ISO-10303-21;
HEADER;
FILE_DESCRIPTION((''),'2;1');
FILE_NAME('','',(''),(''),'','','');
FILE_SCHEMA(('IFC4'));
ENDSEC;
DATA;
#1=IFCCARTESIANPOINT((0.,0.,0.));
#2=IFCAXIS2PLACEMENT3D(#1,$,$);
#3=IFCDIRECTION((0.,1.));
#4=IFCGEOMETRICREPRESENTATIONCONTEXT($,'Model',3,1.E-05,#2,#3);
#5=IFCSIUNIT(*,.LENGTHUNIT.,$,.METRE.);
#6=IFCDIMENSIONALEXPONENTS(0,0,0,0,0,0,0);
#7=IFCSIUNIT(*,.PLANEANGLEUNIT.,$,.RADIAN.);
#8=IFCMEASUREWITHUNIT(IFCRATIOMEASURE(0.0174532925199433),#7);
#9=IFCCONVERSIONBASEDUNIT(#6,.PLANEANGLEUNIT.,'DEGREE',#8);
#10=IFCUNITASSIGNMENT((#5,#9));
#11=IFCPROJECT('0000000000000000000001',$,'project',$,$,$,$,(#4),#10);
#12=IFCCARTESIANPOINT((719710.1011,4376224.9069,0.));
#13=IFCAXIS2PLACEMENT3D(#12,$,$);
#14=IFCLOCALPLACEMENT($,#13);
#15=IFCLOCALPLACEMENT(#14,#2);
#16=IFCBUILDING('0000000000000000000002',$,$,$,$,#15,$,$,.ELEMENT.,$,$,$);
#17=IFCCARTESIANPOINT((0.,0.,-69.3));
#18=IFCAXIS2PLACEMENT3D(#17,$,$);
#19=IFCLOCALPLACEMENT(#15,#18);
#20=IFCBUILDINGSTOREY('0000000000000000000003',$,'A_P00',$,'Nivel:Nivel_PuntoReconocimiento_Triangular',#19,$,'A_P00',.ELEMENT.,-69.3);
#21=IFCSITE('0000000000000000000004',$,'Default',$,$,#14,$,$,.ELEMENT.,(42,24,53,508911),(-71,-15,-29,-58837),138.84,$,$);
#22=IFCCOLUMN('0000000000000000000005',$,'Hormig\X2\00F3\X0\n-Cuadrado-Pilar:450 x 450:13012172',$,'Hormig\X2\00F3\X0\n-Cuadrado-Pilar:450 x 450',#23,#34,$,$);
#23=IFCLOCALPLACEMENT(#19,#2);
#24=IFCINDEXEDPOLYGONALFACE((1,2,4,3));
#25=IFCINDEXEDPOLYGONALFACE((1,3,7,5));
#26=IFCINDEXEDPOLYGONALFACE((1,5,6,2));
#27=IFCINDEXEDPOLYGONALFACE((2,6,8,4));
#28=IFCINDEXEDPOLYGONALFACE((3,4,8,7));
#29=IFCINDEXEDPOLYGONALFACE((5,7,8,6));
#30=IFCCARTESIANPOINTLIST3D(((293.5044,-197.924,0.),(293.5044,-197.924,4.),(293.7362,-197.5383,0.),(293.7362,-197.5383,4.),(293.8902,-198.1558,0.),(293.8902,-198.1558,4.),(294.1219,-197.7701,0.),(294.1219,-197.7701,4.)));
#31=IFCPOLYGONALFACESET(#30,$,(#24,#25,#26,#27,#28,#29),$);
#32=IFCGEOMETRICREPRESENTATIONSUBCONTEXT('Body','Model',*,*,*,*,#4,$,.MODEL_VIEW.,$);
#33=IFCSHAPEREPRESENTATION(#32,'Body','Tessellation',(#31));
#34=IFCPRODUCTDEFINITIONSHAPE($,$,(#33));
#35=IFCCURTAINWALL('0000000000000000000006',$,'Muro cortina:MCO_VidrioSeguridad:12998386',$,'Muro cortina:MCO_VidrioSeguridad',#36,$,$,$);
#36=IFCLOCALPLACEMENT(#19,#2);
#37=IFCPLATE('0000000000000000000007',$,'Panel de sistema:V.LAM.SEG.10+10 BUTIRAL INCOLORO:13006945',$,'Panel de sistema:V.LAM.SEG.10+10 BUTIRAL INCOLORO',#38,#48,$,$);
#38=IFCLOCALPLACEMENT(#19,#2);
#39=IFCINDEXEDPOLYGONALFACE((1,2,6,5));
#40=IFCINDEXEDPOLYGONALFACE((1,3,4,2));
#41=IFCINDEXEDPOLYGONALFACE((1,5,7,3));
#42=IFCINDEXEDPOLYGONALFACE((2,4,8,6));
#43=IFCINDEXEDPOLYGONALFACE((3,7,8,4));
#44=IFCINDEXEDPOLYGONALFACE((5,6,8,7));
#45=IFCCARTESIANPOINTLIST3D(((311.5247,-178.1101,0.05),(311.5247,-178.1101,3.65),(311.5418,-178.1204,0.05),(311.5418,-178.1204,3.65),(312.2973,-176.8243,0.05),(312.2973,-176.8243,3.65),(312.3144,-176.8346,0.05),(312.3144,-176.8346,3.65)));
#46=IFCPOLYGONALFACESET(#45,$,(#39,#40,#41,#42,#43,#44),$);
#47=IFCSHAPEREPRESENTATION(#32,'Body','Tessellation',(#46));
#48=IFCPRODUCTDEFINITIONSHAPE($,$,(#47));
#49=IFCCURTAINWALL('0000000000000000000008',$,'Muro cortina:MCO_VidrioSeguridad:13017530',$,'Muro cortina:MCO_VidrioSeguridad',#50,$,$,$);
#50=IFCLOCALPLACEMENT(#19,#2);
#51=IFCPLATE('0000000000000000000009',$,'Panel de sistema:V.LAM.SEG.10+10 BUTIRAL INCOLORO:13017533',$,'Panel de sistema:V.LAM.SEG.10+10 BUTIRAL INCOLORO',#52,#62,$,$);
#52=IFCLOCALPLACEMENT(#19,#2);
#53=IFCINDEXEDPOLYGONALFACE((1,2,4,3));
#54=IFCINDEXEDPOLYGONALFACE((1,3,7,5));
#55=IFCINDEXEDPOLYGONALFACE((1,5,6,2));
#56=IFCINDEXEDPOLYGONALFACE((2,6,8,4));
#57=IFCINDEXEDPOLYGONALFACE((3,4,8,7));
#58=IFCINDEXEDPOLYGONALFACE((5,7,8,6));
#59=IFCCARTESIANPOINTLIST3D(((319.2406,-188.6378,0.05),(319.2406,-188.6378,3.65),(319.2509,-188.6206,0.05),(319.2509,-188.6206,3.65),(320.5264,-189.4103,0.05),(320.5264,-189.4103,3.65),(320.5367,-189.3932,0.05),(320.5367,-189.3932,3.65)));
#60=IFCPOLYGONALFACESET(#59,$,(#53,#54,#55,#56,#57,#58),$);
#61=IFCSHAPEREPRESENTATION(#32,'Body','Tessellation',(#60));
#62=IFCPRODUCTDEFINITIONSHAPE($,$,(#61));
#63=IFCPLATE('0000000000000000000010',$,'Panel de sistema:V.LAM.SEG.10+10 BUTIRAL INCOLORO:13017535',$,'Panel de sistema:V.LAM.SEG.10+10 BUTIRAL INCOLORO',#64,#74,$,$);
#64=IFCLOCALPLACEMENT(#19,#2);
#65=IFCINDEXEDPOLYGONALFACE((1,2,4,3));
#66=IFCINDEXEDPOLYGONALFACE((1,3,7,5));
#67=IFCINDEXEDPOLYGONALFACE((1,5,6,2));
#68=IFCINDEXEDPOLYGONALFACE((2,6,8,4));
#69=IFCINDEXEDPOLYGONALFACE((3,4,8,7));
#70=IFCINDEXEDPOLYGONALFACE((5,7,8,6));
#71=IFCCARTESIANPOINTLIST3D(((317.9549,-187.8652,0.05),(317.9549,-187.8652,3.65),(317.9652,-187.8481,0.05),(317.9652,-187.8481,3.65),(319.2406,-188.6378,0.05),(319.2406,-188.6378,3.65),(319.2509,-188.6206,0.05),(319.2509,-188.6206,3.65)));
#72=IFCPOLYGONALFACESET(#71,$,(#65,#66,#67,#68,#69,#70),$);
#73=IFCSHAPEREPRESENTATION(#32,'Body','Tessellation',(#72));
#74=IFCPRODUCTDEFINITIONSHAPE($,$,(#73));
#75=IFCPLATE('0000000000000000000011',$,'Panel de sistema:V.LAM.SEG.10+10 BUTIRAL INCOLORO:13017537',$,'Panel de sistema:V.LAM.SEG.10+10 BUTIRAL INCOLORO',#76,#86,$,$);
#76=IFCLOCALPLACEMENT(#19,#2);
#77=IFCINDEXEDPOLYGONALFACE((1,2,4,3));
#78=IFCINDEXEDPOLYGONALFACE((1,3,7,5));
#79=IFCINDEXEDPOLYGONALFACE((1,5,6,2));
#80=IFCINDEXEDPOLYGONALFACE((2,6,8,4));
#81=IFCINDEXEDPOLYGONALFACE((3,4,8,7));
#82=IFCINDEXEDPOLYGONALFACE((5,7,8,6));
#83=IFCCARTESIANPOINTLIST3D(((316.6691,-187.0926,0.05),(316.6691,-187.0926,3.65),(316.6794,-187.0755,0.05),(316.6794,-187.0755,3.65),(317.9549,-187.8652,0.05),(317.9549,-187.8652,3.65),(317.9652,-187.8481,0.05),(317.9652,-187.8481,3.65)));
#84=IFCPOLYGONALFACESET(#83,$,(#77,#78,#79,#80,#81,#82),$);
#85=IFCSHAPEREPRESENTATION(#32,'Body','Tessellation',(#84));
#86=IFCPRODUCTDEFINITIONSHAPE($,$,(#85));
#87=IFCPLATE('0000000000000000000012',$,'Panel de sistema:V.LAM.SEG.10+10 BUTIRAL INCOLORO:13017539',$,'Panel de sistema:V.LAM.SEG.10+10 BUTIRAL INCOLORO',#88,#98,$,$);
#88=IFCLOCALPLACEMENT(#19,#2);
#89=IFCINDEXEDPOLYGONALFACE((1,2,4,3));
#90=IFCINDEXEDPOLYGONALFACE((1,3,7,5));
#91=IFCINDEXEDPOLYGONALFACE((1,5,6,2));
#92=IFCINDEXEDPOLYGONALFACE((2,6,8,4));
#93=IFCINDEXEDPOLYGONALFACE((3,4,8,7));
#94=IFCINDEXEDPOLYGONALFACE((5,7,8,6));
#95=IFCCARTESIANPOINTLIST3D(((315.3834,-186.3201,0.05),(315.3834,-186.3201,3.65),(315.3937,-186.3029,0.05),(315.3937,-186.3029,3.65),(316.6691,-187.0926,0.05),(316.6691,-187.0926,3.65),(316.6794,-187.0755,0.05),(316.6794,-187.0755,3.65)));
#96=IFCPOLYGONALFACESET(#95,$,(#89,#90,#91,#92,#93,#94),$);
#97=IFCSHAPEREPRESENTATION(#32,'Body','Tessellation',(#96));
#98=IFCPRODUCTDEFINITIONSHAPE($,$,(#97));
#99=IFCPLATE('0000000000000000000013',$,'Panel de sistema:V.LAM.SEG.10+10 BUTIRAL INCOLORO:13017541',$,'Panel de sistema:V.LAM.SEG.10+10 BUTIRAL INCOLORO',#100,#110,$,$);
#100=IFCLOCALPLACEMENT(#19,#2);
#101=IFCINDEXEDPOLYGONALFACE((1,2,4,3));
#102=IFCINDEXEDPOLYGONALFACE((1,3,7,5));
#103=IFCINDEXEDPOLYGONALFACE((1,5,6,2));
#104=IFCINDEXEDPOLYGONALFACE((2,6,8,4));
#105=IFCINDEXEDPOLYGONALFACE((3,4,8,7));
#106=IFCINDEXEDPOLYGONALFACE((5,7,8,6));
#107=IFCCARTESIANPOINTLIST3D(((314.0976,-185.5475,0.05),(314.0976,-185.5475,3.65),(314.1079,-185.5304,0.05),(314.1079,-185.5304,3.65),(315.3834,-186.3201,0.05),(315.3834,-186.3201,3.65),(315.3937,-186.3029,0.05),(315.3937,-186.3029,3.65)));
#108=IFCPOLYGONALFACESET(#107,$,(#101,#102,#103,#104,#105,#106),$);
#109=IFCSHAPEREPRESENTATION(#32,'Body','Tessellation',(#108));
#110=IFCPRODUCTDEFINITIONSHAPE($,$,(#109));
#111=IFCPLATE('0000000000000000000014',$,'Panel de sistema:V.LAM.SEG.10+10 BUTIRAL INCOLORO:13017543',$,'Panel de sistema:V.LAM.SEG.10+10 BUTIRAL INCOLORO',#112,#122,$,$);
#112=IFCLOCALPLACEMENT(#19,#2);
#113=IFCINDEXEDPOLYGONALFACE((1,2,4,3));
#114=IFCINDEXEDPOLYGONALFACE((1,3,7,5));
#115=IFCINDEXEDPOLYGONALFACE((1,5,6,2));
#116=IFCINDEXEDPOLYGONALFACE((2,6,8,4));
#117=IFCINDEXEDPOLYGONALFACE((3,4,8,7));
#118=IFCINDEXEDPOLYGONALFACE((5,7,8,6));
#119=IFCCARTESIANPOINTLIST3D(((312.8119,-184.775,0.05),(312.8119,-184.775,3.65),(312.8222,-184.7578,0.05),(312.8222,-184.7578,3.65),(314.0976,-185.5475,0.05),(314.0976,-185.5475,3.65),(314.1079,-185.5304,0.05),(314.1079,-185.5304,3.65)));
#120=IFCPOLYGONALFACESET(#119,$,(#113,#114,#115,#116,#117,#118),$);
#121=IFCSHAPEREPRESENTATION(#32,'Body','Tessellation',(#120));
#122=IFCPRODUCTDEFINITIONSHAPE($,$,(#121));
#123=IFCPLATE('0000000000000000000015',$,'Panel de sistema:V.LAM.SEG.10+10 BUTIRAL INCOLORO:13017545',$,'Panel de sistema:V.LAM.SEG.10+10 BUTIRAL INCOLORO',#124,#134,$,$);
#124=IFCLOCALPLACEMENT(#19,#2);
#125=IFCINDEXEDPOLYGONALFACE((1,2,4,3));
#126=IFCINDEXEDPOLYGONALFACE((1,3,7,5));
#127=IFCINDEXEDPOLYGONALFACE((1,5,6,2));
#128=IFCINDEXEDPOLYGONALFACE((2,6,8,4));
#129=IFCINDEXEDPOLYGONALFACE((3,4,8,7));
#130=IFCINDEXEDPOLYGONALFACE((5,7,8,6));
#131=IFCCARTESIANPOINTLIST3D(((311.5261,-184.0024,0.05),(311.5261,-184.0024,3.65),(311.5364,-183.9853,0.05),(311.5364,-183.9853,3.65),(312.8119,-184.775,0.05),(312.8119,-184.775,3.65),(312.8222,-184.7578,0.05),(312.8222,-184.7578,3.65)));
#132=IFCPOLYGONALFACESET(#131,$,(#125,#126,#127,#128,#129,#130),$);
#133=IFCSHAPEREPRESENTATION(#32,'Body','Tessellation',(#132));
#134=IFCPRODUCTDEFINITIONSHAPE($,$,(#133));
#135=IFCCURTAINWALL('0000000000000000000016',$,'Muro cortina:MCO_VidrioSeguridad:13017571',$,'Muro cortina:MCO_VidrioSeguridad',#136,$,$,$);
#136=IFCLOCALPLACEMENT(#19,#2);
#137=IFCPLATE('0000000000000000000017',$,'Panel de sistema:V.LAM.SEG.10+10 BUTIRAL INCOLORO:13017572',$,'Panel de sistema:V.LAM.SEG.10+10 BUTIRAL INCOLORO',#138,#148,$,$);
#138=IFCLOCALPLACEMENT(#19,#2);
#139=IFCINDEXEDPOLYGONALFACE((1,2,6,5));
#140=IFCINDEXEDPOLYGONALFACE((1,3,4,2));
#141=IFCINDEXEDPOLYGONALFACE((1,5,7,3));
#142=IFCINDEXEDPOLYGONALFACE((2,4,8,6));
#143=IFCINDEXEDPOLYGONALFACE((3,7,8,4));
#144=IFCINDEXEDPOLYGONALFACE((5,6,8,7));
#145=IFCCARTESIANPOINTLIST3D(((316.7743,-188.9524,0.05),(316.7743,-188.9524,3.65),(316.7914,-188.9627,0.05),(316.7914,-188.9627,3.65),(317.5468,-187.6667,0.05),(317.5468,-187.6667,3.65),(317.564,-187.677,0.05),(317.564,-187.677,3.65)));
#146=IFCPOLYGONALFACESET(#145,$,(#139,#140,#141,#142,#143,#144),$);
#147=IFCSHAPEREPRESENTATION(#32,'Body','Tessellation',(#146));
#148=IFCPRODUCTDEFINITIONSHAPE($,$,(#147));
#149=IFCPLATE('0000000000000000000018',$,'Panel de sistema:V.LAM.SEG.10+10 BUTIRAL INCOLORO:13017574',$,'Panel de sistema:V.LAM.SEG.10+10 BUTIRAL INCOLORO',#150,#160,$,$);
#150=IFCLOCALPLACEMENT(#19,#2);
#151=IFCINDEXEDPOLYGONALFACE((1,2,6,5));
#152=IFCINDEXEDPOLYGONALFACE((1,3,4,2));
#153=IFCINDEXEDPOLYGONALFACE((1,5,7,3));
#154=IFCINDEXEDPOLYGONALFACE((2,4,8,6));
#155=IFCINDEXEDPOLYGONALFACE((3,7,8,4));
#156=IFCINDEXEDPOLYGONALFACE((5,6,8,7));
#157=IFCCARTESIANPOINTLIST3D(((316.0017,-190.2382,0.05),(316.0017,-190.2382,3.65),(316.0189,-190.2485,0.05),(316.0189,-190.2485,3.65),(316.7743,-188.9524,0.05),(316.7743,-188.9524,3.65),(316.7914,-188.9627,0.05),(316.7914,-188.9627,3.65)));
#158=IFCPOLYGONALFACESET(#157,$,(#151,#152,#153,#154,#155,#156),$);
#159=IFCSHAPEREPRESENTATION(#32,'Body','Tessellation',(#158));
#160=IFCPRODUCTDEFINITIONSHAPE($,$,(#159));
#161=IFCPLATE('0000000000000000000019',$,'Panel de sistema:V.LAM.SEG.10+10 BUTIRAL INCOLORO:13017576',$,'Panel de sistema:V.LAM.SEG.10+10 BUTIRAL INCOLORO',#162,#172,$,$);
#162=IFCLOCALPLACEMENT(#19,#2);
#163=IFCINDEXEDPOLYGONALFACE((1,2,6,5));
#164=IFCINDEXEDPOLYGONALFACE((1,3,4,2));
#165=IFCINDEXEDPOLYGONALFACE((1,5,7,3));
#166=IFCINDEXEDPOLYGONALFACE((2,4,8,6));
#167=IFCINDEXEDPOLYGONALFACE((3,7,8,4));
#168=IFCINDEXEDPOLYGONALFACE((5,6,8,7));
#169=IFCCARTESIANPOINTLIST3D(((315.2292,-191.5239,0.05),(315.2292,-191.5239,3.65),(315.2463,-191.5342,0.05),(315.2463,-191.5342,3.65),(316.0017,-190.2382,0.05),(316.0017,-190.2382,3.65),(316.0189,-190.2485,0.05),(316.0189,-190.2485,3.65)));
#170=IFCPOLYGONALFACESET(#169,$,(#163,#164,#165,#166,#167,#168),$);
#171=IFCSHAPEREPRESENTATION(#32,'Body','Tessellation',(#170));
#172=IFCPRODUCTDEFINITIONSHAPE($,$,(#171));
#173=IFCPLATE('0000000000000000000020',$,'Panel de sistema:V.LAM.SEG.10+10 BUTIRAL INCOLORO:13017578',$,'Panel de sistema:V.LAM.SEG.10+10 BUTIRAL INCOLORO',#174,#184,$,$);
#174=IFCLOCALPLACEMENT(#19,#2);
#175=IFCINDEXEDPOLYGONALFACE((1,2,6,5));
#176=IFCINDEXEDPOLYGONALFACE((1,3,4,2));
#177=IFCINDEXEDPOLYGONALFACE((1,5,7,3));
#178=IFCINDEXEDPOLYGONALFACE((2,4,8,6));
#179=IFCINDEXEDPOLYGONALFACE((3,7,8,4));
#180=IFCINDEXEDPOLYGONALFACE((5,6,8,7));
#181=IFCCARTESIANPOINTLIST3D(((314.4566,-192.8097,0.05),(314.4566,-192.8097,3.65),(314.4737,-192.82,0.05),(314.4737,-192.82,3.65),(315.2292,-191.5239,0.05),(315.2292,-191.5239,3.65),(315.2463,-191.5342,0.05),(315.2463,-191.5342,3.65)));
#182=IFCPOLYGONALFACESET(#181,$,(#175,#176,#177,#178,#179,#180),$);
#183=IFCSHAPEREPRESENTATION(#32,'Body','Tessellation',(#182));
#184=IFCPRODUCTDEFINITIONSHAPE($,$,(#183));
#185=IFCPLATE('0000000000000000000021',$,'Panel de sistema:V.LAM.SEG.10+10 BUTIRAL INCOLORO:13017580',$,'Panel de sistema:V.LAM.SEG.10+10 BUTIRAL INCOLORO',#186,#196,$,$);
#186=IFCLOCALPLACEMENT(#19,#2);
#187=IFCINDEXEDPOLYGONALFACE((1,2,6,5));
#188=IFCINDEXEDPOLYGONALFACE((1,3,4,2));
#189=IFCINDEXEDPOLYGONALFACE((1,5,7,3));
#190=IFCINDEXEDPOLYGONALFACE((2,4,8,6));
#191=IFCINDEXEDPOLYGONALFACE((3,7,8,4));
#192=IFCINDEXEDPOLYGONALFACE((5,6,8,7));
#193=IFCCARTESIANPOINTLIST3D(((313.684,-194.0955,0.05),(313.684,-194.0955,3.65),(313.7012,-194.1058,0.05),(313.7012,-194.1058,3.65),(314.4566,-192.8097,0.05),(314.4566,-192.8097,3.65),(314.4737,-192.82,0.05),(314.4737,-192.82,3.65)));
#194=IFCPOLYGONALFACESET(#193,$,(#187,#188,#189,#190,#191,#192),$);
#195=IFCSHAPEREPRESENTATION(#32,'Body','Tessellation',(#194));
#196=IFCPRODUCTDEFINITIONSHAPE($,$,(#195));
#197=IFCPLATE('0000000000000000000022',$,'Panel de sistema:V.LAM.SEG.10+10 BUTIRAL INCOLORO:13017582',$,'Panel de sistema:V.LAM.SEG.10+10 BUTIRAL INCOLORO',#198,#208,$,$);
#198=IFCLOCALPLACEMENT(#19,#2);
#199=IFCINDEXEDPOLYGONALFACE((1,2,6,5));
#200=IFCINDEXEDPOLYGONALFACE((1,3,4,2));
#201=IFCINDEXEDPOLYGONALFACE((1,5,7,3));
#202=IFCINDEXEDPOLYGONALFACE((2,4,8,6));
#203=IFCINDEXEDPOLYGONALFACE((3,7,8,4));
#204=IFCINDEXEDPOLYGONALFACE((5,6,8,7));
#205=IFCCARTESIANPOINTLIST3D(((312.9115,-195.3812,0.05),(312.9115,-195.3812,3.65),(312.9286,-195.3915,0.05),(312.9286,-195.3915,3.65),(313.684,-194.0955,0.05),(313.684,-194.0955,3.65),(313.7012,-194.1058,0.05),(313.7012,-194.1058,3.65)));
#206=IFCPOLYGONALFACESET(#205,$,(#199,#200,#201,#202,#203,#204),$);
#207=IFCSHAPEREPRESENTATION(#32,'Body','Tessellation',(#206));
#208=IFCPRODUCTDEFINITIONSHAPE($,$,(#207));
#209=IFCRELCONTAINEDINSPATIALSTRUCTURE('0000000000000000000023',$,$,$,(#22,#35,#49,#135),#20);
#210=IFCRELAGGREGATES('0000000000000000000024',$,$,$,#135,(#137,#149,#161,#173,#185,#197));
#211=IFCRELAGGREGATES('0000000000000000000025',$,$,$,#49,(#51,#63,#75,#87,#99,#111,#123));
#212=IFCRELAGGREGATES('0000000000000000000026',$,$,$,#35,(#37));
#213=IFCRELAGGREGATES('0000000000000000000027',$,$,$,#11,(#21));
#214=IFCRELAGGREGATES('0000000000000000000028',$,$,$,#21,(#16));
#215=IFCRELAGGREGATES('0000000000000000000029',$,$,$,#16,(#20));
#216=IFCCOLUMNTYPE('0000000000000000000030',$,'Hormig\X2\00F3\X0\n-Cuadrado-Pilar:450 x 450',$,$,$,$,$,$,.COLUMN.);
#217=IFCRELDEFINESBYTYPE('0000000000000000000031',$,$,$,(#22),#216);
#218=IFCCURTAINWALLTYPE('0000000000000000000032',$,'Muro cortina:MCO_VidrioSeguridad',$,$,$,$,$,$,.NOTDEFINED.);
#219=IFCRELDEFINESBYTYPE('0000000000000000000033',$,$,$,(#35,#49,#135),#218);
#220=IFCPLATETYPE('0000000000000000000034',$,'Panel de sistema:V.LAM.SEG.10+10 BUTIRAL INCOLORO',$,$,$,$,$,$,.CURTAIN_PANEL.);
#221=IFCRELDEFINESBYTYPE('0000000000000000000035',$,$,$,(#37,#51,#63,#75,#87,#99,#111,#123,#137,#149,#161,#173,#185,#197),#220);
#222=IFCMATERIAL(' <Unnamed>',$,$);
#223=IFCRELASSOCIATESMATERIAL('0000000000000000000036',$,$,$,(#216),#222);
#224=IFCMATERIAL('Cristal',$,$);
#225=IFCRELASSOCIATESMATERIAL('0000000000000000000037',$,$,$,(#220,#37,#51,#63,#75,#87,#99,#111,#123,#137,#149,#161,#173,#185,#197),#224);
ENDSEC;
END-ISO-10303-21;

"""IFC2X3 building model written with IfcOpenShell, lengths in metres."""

from ifc_helpers import new_model, entity, si_unit, converted_unit, direction, frame, origin, origin_2d_with_axis, place, context, subcontext, project, spatial, rectangle, extrude, source, transform, mapped, material, type_object, type_shapes, element, aggregate, save


model = new_model("IFC2X3")

# Units and contexts
model_context = context("Model", 3, precision=1e-05, world=origin(), true_north=direction((0.0, 1.0)))
body_context = subcontext(model_context, "Body", "Model", "MODEL_VIEW")
ifc_project = project(units=[si_unit("LENGTHUNIT", "METRE"), converted_unit("PLANEANGLEUNIT", "DEGREE", entity("IfcRatioMeasure", 0.0174532925199433), si_unit("PLANEANGLEUNIT", "RADIAN"), dimensions=[0, 0, 0, 0, 0, 0, 0])], contexts=[model_context])

# Site, building, storey
site_placement = place(None, frame((719710.1011, 4376224.9069, 0.0)))
site = spatial("IfcSite", under=ifc_project, at=site_placement, Name="Default", CompositionType="ELEMENT", RefLatitude=(42, 24, 53, 508911), RefLongitude=(-71, -15, -29, -58837), RefElevation=138.84)
building_placement = place(site_placement, origin())
building = spatial("IfcBuilding", under=site, at=building_placement, CompositionType="ELEMENT")
storey_placement = place(building_placement, frame((0.0, 0.0, -69.3)))
storey = spatial("IfcBuildingStorey", under=building, at=storey_placement, Name="A_P00", ObjectType="Nivel:Nivel_PuntoReconocimiento_Triangular", LongName="A_P00", CompositionType="ELEMENT", Elevation=-69.3)

# Column
ifc_material_1 = material(Name=" <Unnamed>")
column_type = type_object("IfcColumnType", Name="Hormigón-Cuadrado-Pilar:450 x 450", PredefinedType="COLUMN", material=ifc_material_1)
shared_shape_1 = source(origin(), body_context, "Body", "SweptSolid", [
    extrude(rectangle(XDim=0.45, YDim=0.45, at=origin_2d_with_axis()), frame((0.0, 0.0, -69.3), z_axis=(0.0, 0.0, 1.0), x_axis=(0.0, -1.0, 0.0)), (0.0, 0.0, 1.0), 4.0),
])
type_shapes(column_type, [shared_shape_1])
column_placement = place(storey_placement, frame((293.8132, -197.8471, 69.3), z_axis=(0.0, 0.0, 1.0), x_axis=(0.857167, -0.515038, 0.0)))
element("IfcColumn", 1, at=column_placement, inside=storey, type_object=column_type, Name="Hormigón-Cuadrado-Pilar:450 x 450:13012172", ObjectType="Hormigón-Cuadrado-Pilar:450 x 450", context=body_context, shape_type="MappedRepresentation", body=[
    mapped(shared_shape_1, transform((0.0, 0.0, 0.0), scale=1.0)),
])

# Curtain wall, plate
curtain_wall_type = type_object("IfcCurtainWallType", Name="Muro cortina:MCO_VidrioSeguridad", PredefinedType="NOTDEFINED")
curtain_wall_1_placement = place(storey_placement, frame((0.0, 0.0, 69.3)))
curtain_wall_1 = element("IfcCurtainWall", 2, at=curtain_wall_1_placement, inside=storey, type_object=curtain_wall_type, Name="Muro cortina:MCO_VidrioSeguridad:12998386", ObjectType="Muro cortina:MCO_VidrioSeguridad")
ifc_material_2 = material(Name="Cristal")
plate_type_1 = type_object("IfcPlateType", Name="Panel de sistema:V.LAM.SEG.10+10 BUTIRAL INCOLORO", PredefinedType="CURTAIN_PANEL", material=ifc_material_2)
shared_shape_2 = source(origin(), body_context, "Body", "SweptSolid", [
    extrude(rectangle(XDim=0.02, YDim=1.5, at=origin_2d_with_axis()), frame((0.0, 0.0, 0.0), z_axis=(0.0, 0.0, 1.0), x_axis=(0.0, 1.0, 0.0)), (0.0, 0.0, 1.0), 3.6),
])
type_shapes(plate_type_1, [shared_shape_2])
plate_1_placement = place(curtain_wall_1_placement, frame((311.9195, -177.4723, -69.25), z_axis=(0.0, 0.0, 1.0), x_axis=(0.515038, 0.857167, 0.0)))
plate_1 = element("IfcPlate", 3, at=plate_1_placement, type_object=plate_type_1, material=ifc_material_2, Name="Panel de sistema:V.LAM.SEG.10+10 BUTIRAL INCOLORO:13006945", ObjectType="Panel de sistema:V.LAM.SEG.10+10 BUTIRAL INCOLORO", context=body_context, shape_type="MappedRepresentation", body=[
    mapped(shared_shape_2, transform((0.0, 0.0, 0.0), scale=1.0)),
])

# Curtain walls, plates
curtain_wall_2_placement = place(storey_placement, frame((0.0, 0.0, 69.3)))
curtain_wall_2 = element("IfcCurtainWall", 4, at=curtain_wall_2_placement, inside=storey, type_object=curtain_wall_type, Name="Muro cortina:MCO_VidrioSeguridad:13017530", ObjectType="Muro cortina:MCO_VidrioSeguridad")
plate_2_placement = place(curtain_wall_2_placement, frame((319.8886, -189.0155, -69.25), z_axis=(0.0, 0.0, 1.0), x_axis=(-0.857167, 0.515038, 0.0)))
plate_2 = element("IfcPlate", 5, at=plate_2_placement, type_object=plate_type_1, material=ifc_material_2, Name="Panel de sistema:V.LAM.SEG.10+10 BUTIRAL INCOLORO:13017533", ObjectType="Panel de sistema:V.LAM.SEG.10+10 BUTIRAL INCOLORO", context=body_context, shape_type="MappedRepresentation", body=[
    mapped(shared_shape_2, transform((0.0, 0.0, 0.0), scale=1.0)),
])
plate_3_placement = place(curtain_wall_2_placement, frame((318.6029, -188.2429, -69.25), z_axis=(0.0, 0.0, 1.0), x_axis=(-0.857167, 0.515038, 0.0)))
plate_3 = element("IfcPlate", 6, at=plate_3_placement, type_object=plate_type_1, material=ifc_material_2, Name="Panel de sistema:V.LAM.SEG.10+10 BUTIRAL INCOLORO:13017535", ObjectType="Panel de sistema:V.LAM.SEG.10+10 BUTIRAL INCOLORO", context=body_context, shape_type="MappedRepresentation", body=[
    mapped(shared_shape_2, transform((0.0, 0.0, 0.0), scale=1.0)),
])
plate_4_placement = place(curtain_wall_2_placement, frame((317.3171, -187.4704, -69.25), z_axis=(0.0, 0.0, 1.0), x_axis=(-0.857167, 0.515038, 0.0)))
plate_4 = element("IfcPlate", 7, at=plate_4_placement, type_object=plate_type_1, material=ifc_material_2, Name="Panel de sistema:V.LAM.SEG.10+10 BUTIRAL INCOLORO:13017537", ObjectType="Panel de sistema:V.LAM.SEG.10+10 BUTIRAL INCOLORO", context=body_context, shape_type="MappedRepresentation", body=[
    mapped(shared_shape_2, transform((0.0, 0.0, 0.0), scale=1.0)),
])
plate_5_placement = place(curtain_wall_2_placement, frame((316.0314, -186.6978, -69.25), z_axis=(0.0, 0.0, 1.0), x_axis=(-0.857167, 0.515038, 0.0)))
plate_5 = element("IfcPlate", 8, at=plate_5_placement, type_object=plate_type_1, material=ifc_material_2, Name="Panel de sistema:V.LAM.SEG.10+10 BUTIRAL INCOLORO:13017539", ObjectType="Panel de sistema:V.LAM.SEG.10+10 BUTIRAL INCOLORO", context=body_context, shape_type="MappedRepresentation", body=[
    mapped(shared_shape_2, transform((0.0, 0.0, 0.0), scale=1.0)),
])
plate_6_placement = place(curtain_wall_2_placement, frame((314.7456, -185.9252, -69.25), z_axis=(0.0, 0.0, 1.0), x_axis=(-0.857167, 0.515038, 0.0)))
plate_6 = element("IfcPlate", 9, at=plate_6_placement, type_object=plate_type_1, material=ifc_material_2, Name="Panel de sistema:V.LAM.SEG.10+10 BUTIRAL INCOLORO:13017541", ObjectType="Panel de sistema:V.LAM.SEG.10+10 BUTIRAL INCOLORO", context=body_context, shape_type="MappedRepresentation", body=[
    mapped(shared_shape_2, transform((0.0, 0.0, 0.0), scale=1.0)),
])
plate_7_placement = place(curtain_wall_2_placement, frame((313.4599, -185.1527, -69.25), z_axis=(0.0, 0.0, 1.0), x_axis=(-0.857167, 0.515038, 0.0)))
plate_7 = element("IfcPlate", 10, at=plate_7_placement, type_object=plate_type_1, material=ifc_material_2, Name="Panel de sistema:V.LAM.SEG.10+10 BUTIRAL INCOLORO:13017543", ObjectType="Panel de sistema:V.LAM.SEG.10+10 BUTIRAL INCOLORO", context=body_context, shape_type="MappedRepresentation", body=[
    mapped(shared_shape_2, transform((0.0, 0.0, 0.0), scale=1.0)),
])
plate_8_placement = place(curtain_wall_2_placement, frame((312.1741, -184.3801, -69.25), z_axis=(0.0, 0.0, 1.0), x_axis=(-0.857167, 0.515038, 0.0)))
plate_8 = element("IfcPlate", 11, at=plate_8_placement, type_object=plate_type_1, material=ifc_material_2, Name="Panel de sistema:V.LAM.SEG.10+10 BUTIRAL INCOLORO:13017545", ObjectType="Panel de sistema:V.LAM.SEG.10+10 BUTIRAL INCOLORO", context=body_context, shape_type="MappedRepresentation", body=[
    mapped(shared_shape_2, transform((0.0, 0.0, 0.0), scale=1.0)),
])
curtain_wall_3_placement = place(storey_placement, frame((0.0, 0.0, 69.3)))
curtain_wall_3 = element("IfcCurtainWall", 12, at=curtain_wall_3_placement, inside=storey, type_object=curtain_wall_type, Name="Muro cortina:MCO_VidrioSeguridad:13017571", ObjectType="Muro cortina:MCO_VidrioSeguridad")
plate_9_placement = place(curtain_wall_3_placement, frame((317.1691, -188.3147, -69.25), z_axis=(0.0, 0.0, 1.0), x_axis=(-0.515038, -0.857167, 0.0)))
plate_9 = element("IfcPlate", 13, at=plate_9_placement, type_object=plate_type_1, material=ifc_material_2, Name="Panel de sistema:V.LAM.SEG.10+10 BUTIRAL INCOLORO:13017572", ObjectType="Panel de sistema:V.LAM.SEG.10+10 BUTIRAL INCOLORO", context=body_context, shape_type="MappedRepresentation", body=[
    mapped(shared_shape_2, transform((0.0, 0.0, 0.0), scale=1.0)),
])
plate_10_placement = place(curtain_wall_3_placement, frame((316.3966, -189.6005, -69.25), z_axis=(0.0, 0.0, 1.0), x_axis=(-0.515038, -0.857167, 0.0)))
plate_10 = element("IfcPlate", 14, at=plate_10_placement, type_object=plate_type_1, material=ifc_material_2, Name="Panel de sistema:V.LAM.SEG.10+10 BUTIRAL INCOLORO:13017574", ObjectType="Panel de sistema:V.LAM.SEG.10+10 BUTIRAL INCOLORO", context=body_context, shape_type="MappedRepresentation", body=[
    mapped(shared_shape_2, transform((0.0, 0.0, 0.0), scale=1.0)),
])
plate_11_placement = place(curtain_wall_3_placement, frame((315.624, -190.8862, -69.25), z_axis=(0.0, 0.0, 1.0), x_axis=(-0.515038, -0.857167, 0.0)))
plate_11 = element("IfcPlate", 15, at=plate_11_placement, type_object=plate_type_1, material=ifc_material_2, Name="Panel de sistema:V.LAM.SEG.10+10 BUTIRAL INCOLORO:13017576", ObjectType="Panel de sistema:V.LAM.SEG.10+10 BUTIRAL INCOLORO", context=body_context, shape_type="MappedRepresentation", body=[
    mapped(shared_shape_2, transform((0.0, 0.0, 0.0), scale=1.0)),
])
plate_12_placement = place(curtain_wall_3_placement, frame((314.8514, -192.172, -69.25), z_axis=(0.0, 0.0, 1.0), x_axis=(-0.515038, -0.857167, 0.0)))
plate_12 = element("IfcPlate", 16, at=plate_12_placement, type_object=plate_type_1, material=ifc_material_2, Name="Panel de sistema:V.LAM.SEG.10+10 BUTIRAL INCOLORO:13017578", ObjectType="Panel de sistema:V.LAM.SEG.10+10 BUTIRAL INCOLORO", context=body_context, shape_type="MappedRepresentation", body=[
    mapped(shared_shape_2, transform((0.0, 0.0, 0.0), scale=1.0)),
])
plate_13_placement = place(curtain_wall_3_placement, frame((314.0789, -193.4577, -69.25), z_axis=(0.0, 0.0, 1.0), x_axis=(-0.515038, -0.857167, 0.0)))
plate_13 = element("IfcPlate", 17, at=plate_13_placement, type_object=plate_type_1, material=ifc_material_2, Name="Panel de sistema:V.LAM.SEG.10+10 BUTIRAL INCOLORO:13017580", ObjectType="Panel de sistema:V.LAM.SEG.10+10 BUTIRAL INCOLORO", context=body_context, shape_type="MappedRepresentation", body=[
    mapped(shared_shape_2, transform((0.0, 0.0, 0.0), scale=1.0)),
])
plate_14_placement = place(curtain_wall_3_placement, frame((313.3063, -194.7435, -69.25), z_axis=(0.0, 0.0, 1.0), x_axis=(-0.515038, -0.857167, 0.0)))
plate_14 = element("IfcPlate", 18, at=plate_14_placement, type_object=plate_type_1, material=ifc_material_2, Name="Panel de sistema:V.LAM.SEG.10+10 BUTIRAL INCOLORO:13017582", ObjectType="Panel de sistema:V.LAM.SEG.10+10 BUTIRAL INCOLORO", context=body_context, shape_type="MappedRepresentation", body=[
    mapped(shared_shape_2, transform((0.0, 0.0, 0.0), scale=1.0)),
])
aggregate(curtain_wall_3, [plate_9, plate_10, plate_11, plate_12, plate_13, plate_14])

aggregate(curtain_wall_2, [plate_2, plate_3, plate_4, plate_5, plate_6, plate_7, plate_8])
aggregate(curtain_wall_1, [plate_1])

save(model, "model.ifc")
